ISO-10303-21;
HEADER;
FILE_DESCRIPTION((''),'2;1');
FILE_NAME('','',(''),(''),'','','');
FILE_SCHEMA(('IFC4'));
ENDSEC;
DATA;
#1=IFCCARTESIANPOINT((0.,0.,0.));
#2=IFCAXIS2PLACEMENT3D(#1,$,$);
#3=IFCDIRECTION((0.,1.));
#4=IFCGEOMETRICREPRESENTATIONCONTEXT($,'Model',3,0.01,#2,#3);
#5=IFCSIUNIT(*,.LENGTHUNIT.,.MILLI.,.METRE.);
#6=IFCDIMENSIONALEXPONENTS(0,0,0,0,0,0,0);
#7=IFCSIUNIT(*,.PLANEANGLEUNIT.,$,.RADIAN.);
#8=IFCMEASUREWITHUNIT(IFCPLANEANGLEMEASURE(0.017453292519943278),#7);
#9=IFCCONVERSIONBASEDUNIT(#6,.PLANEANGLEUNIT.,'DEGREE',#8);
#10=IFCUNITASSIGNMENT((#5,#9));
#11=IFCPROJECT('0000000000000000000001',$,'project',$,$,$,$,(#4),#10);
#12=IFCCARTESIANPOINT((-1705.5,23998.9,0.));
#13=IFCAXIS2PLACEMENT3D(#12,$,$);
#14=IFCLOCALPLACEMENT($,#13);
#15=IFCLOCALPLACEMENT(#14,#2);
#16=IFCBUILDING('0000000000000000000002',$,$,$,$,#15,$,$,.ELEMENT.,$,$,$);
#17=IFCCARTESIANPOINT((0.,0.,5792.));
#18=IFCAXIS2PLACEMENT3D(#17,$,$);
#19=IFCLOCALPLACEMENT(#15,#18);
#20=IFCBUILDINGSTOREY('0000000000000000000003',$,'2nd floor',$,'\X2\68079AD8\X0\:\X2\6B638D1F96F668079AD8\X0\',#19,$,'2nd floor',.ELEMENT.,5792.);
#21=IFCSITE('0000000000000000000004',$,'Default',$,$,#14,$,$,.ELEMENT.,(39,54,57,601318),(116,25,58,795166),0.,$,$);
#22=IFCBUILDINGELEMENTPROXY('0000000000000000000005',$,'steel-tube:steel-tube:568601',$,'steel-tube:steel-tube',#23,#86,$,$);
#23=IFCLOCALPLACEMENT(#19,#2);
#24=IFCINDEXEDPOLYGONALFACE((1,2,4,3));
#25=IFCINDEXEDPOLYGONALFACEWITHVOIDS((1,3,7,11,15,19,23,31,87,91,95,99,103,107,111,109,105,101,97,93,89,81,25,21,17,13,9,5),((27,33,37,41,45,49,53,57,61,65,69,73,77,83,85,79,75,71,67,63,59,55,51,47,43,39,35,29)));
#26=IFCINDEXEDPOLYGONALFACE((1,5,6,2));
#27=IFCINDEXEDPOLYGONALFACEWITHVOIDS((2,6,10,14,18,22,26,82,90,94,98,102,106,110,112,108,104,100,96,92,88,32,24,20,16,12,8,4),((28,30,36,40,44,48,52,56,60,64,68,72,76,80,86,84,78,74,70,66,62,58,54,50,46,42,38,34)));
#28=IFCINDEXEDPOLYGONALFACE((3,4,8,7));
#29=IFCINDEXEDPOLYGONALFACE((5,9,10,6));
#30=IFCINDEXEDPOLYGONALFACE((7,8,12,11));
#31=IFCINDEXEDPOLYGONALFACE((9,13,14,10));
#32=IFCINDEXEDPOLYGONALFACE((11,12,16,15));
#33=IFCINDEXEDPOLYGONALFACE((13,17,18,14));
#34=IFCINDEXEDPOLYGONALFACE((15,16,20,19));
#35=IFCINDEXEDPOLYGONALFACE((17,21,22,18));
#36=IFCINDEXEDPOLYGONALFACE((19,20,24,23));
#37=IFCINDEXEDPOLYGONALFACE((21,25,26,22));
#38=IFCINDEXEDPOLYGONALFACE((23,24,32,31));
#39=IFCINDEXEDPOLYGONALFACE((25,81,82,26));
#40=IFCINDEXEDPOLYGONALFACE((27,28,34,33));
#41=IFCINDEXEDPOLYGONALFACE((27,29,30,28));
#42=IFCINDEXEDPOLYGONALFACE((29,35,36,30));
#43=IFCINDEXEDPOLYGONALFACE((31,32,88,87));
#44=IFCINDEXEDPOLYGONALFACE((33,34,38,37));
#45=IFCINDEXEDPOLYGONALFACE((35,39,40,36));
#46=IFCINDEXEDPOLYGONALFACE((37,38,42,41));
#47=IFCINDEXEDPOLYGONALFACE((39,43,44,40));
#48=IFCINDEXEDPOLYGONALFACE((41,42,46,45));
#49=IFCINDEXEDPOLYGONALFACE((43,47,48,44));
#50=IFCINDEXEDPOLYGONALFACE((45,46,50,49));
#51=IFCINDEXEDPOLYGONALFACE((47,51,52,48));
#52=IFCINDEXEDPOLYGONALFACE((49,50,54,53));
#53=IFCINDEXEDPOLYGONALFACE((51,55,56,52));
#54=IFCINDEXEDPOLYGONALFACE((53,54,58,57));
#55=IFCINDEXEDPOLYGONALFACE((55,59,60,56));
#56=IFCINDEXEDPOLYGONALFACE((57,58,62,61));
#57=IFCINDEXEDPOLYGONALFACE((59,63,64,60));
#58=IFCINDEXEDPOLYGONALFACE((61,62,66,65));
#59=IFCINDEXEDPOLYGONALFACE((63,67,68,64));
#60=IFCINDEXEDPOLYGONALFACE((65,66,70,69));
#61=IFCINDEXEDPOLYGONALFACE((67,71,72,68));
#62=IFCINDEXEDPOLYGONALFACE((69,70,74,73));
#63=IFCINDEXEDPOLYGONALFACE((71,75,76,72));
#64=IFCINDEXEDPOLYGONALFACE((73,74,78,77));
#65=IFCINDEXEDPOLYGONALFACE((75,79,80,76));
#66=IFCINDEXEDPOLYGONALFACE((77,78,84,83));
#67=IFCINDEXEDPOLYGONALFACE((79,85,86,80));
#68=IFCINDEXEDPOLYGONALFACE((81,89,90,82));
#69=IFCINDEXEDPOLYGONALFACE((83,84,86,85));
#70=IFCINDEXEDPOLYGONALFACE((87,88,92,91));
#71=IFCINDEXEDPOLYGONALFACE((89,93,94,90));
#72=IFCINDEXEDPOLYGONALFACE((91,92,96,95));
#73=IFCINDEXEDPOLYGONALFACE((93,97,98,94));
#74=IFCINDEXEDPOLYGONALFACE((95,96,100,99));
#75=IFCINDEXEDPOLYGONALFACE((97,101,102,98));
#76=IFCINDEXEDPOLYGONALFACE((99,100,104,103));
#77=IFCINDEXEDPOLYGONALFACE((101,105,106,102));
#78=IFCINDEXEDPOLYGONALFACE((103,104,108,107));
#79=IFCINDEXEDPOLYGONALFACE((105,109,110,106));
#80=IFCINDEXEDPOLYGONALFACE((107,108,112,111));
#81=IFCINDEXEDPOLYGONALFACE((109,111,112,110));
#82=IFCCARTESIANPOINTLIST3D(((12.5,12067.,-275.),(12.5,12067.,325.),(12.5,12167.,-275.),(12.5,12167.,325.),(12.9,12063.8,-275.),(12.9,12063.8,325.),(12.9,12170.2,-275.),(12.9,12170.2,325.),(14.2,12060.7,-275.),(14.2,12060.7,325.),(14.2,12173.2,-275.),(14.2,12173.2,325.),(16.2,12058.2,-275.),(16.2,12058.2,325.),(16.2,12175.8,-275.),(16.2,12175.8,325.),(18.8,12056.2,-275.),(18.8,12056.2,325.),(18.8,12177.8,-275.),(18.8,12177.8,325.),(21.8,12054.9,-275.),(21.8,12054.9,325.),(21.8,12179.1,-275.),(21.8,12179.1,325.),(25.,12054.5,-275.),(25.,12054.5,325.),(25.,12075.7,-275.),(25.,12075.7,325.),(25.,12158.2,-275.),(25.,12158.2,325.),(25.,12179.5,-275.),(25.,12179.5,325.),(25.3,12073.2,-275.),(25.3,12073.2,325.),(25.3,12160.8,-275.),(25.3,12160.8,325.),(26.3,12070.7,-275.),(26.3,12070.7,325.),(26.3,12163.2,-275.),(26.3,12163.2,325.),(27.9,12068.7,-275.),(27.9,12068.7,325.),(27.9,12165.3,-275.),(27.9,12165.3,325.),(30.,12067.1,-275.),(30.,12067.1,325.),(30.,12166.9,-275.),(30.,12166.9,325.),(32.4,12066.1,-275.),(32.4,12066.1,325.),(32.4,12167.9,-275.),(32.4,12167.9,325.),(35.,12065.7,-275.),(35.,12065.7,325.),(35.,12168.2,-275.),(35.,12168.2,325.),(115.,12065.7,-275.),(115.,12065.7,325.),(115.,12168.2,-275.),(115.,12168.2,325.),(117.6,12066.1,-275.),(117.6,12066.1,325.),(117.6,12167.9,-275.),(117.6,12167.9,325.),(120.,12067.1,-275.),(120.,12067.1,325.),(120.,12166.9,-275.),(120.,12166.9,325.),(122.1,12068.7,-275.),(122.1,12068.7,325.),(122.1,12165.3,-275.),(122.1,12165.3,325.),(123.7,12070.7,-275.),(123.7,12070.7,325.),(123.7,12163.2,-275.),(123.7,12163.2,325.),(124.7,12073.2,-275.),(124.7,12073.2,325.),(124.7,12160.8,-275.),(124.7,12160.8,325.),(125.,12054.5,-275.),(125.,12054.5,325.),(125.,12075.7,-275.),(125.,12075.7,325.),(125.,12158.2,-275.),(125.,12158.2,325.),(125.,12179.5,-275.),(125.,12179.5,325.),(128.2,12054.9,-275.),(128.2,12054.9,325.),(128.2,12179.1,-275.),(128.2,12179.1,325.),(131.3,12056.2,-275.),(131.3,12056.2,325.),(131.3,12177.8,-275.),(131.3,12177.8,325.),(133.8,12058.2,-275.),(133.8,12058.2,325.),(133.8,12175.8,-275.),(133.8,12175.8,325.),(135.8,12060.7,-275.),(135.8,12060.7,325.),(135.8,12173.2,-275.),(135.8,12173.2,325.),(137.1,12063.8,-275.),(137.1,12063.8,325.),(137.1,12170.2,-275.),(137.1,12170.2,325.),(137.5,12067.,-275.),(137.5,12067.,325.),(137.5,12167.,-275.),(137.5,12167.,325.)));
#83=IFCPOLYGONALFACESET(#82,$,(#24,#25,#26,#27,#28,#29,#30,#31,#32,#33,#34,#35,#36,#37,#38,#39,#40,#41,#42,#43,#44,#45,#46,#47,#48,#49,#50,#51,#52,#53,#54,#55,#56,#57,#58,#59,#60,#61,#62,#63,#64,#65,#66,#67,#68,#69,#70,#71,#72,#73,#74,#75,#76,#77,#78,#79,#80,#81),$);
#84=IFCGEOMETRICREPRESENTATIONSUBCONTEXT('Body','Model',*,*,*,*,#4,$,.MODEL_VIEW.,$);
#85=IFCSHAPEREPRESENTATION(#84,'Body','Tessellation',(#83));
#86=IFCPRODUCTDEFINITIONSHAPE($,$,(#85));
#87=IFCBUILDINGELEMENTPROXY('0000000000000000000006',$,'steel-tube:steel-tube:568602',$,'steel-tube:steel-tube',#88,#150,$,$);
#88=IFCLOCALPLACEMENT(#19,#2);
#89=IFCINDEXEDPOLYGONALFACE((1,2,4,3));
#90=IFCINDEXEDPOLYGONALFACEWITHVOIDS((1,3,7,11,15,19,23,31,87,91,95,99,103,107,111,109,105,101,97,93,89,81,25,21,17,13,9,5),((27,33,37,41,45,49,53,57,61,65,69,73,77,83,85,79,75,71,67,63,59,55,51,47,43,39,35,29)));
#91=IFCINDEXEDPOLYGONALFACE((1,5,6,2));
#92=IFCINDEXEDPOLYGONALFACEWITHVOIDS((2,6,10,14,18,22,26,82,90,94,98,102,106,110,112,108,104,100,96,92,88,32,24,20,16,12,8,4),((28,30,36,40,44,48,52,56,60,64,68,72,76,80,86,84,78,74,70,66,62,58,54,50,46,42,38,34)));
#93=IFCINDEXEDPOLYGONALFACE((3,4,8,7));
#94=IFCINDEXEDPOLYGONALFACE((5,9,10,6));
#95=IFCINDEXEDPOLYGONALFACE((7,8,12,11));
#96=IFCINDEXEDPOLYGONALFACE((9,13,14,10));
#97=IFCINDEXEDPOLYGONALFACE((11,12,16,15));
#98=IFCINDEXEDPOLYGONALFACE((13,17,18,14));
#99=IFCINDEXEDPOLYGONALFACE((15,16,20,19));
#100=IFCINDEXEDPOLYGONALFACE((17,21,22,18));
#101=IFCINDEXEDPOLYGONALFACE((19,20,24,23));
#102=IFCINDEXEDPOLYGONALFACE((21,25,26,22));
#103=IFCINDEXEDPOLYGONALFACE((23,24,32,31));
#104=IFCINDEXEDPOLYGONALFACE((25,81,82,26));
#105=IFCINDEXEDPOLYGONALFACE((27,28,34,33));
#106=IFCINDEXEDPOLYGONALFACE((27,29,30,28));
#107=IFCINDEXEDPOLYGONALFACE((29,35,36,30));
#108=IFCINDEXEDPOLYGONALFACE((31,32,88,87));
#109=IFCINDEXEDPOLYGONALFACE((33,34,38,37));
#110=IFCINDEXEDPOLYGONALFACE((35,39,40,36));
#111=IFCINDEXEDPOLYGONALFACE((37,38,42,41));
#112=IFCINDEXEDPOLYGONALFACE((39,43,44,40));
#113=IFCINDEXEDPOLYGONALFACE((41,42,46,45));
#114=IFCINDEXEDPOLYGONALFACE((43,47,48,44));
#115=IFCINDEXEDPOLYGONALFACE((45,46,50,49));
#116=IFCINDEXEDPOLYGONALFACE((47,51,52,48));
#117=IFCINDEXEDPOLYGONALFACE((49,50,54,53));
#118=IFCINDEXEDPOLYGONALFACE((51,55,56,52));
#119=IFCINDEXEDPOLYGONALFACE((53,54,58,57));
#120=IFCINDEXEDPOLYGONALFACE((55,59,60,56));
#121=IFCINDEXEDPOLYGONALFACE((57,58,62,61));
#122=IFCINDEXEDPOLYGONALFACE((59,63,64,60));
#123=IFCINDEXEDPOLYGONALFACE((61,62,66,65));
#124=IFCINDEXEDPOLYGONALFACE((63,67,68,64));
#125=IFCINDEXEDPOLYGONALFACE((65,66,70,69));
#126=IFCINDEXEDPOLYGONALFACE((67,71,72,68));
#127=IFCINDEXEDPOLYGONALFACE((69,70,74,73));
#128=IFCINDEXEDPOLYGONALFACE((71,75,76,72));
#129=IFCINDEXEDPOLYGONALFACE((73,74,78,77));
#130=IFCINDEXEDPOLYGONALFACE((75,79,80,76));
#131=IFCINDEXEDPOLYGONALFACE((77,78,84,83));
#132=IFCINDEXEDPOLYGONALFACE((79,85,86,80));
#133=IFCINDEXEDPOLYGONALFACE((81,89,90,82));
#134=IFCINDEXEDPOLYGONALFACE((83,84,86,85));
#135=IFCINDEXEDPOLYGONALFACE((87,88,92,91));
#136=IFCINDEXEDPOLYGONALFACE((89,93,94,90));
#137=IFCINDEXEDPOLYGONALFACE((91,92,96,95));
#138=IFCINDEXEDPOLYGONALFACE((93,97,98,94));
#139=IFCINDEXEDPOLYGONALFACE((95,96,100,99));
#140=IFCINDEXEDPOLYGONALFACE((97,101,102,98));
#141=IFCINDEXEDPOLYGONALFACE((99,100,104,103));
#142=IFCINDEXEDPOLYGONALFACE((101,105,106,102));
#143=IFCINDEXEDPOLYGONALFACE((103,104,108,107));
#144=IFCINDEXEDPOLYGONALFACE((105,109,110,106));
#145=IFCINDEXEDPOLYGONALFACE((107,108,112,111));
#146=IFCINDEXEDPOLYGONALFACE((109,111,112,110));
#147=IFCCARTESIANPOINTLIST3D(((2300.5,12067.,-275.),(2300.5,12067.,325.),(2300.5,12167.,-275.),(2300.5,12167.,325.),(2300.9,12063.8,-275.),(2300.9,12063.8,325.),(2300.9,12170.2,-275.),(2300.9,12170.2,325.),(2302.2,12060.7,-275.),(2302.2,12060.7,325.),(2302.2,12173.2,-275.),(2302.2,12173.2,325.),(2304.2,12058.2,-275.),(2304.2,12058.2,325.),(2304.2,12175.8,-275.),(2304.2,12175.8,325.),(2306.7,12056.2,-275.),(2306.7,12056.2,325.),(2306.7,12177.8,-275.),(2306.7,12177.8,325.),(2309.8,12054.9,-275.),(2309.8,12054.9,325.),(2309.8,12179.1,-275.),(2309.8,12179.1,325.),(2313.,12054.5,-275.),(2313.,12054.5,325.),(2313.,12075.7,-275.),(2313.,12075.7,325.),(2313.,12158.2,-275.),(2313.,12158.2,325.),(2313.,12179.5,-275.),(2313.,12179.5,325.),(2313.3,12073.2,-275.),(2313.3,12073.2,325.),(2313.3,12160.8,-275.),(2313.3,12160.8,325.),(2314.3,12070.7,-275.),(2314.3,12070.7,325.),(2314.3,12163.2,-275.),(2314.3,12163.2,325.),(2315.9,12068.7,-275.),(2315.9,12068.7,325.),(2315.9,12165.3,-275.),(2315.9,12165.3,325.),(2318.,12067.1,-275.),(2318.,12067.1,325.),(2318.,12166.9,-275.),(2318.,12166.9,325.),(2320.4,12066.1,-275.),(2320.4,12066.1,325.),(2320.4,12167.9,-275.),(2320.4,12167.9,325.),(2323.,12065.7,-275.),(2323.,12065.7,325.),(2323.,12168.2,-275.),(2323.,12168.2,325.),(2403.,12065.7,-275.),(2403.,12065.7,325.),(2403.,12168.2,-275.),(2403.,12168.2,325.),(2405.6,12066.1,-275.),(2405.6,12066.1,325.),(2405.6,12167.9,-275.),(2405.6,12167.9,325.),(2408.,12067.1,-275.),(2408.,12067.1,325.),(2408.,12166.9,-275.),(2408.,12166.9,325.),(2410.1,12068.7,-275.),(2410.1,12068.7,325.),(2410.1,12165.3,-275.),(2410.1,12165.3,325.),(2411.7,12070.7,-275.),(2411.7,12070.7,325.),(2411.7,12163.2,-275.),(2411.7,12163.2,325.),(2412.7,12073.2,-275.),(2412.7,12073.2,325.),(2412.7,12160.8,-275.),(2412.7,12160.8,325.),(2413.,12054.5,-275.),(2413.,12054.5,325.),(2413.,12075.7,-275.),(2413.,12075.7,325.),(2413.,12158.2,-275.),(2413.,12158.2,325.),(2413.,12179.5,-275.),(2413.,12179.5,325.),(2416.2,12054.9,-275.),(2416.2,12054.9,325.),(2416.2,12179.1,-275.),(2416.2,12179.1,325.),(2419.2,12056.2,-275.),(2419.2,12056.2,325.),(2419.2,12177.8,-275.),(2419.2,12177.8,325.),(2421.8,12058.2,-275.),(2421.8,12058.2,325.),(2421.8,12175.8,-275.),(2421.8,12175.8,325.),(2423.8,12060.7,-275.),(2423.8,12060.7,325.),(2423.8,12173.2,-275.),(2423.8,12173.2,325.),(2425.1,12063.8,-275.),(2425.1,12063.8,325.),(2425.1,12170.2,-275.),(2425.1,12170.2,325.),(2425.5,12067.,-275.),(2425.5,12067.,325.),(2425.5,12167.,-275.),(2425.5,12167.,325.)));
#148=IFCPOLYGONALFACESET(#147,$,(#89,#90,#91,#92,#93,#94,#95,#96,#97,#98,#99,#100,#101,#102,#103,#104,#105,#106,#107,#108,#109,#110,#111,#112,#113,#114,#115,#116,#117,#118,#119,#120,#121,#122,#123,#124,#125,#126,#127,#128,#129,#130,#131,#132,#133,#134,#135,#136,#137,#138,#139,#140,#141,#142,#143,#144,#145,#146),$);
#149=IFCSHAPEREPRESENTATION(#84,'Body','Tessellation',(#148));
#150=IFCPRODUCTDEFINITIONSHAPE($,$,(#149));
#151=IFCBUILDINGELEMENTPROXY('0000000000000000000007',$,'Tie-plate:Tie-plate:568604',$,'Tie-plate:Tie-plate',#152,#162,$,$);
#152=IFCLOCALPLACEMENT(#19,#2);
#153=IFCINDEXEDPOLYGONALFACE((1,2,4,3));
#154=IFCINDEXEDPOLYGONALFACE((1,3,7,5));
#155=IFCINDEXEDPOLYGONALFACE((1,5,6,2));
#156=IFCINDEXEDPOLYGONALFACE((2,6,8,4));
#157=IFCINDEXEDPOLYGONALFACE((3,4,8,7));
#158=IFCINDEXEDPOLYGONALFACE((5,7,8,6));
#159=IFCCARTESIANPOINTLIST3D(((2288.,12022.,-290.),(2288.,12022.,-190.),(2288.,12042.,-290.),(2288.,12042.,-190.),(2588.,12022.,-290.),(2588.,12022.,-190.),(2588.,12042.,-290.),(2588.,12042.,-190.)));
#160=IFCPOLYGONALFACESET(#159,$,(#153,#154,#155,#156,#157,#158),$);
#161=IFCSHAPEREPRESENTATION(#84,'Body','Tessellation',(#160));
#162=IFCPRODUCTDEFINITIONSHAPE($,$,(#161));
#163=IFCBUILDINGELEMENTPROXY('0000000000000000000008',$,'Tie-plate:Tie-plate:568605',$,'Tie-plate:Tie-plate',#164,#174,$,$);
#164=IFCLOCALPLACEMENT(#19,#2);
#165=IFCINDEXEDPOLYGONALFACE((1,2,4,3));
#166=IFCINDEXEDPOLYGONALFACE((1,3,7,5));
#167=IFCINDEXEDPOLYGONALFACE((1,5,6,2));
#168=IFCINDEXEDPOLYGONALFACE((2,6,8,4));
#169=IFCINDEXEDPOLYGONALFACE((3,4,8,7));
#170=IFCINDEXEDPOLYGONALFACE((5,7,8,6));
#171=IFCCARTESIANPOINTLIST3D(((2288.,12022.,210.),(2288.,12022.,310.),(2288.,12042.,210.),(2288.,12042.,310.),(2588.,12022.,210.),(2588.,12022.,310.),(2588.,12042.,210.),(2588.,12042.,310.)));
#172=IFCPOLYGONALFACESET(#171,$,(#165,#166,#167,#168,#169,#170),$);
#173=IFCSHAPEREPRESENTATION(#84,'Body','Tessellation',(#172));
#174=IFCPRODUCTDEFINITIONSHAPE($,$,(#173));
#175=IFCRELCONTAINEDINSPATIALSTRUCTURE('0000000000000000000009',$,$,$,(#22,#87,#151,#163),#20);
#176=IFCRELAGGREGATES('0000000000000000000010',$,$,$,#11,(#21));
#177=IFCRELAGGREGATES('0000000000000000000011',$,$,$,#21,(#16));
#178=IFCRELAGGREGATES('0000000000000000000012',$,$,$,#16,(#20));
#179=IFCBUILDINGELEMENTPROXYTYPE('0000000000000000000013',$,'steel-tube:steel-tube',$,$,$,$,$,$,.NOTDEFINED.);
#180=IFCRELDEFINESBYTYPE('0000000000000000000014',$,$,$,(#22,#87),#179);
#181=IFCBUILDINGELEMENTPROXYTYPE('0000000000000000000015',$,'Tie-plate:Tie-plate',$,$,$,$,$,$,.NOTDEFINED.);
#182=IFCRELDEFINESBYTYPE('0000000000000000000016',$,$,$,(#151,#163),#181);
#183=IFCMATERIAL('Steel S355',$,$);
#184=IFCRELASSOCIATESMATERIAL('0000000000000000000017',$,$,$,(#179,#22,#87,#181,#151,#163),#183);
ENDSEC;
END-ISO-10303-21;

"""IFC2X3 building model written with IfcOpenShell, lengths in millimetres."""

from ifc_helpers import new_model, entity, si_unit, converted_unit, direction, frame, frame_2d, origin, place, context, subcontext, project, spatial, polyline, circle_curve, parameter, trimmed, segment, composite_curve, rectangle, outline, extrude, source, transform, mapped, material, type_object, type_shapes, element, save


model = new_model("IFC2X3")

# Units and contexts
model_context = context("Model", 3, precision=0.01, world=origin(), true_north=direction((0.0, 1.0)))
body_context = subcontext(model_context, "Body", "Model", "MODEL_VIEW")
ifc_project = project(units=[si_unit("LENGTHUNIT", "METRE", prefix="MILLI"), converted_unit("PLANEANGLEUNIT", "DEGREE", entity("IfcPlaneAngleMeasure", 0.017453292519943278), si_unit("PLANEANGLEUNIT", "RADIAN"), dimensions=[0, 0, 0, 0, 0, 0, 0])], contexts=[model_context])

# Site, building, storey
site_placement = place(None, frame((-1705.5, 23998.9, 0.0)))
site = spatial("IfcSite", under=ifc_project, at=site_placement, Name="Default", CompositionType="ELEMENT", RefLatitude=(39, 54, 57, 601318), RefLongitude=(116, 25, 58, 795166), RefElevation=0.0)
building_placement = place(site_placement, origin())
building = spatial("IfcBuilding", under=site, at=building_placement, CompositionType="ELEMENT")
storey_placement = place(building_placement, frame((0.0, 0.0, 5792.0)))
storey = spatial("IfcBuildingStorey", under=building, at=storey_placement, Name="2nd floor", ObjectType="标高:正负零标高", LongName="2nd floor", CompositionType="ELEMENT", Elevation=5792.0)

# Shared definitions
ifc_material_1 = material(Name="Steel S355")

# Building element proxies
building_element_proxy_type_1 = type_object("IfcBuildingElementProxyType", Name="steel-tube:steel-tube", PredefinedType="NOTDEFINED", material=ifc_material_1)
shared_shape_1 = source(origin(), body_context, "Body", "SweptSolid", [
    extrude(outline(composite_curve([segment(trimmed(circle_curve(frame_2d((50.0, -50.0), x_axis=(1.0, 0.0)), 12.5), [parameter(270.0)], [parameter(0.0)], True, "PARAMETER"), True, "CONTINUOUS"), segment(polyline([(62.5, -50.0), (62.5, 50.0)]), True, "CONTINUOUS"), segment(trimmed(circle_curve(frame_2d((50.0, 50.0), x_axis=(1.0, 0.0)), 12.5), [parameter(0.0)], [parameter(90.0)], True, "PARAMETER"), True, "CONTINUOUS"), segment(polyline([(50.0, 62.5), (-50.0, 62.5)]), True, "CONTINUOUS"), segment(trimmed(circle_curve(frame_2d((-50.0, 50.0), x_axis=(1.0, 0.0)), 12.5), [parameter(90.0)], [parameter(180.0)], True, "PARAMETER"), True, "CONTINUOUS"), segment(polyline([(-62.5, 50.0), (-62.5, -50.0)]), True, "CONTINUOUS"), segment(trimmed(circle_curve(frame_2d((-50.0, -50.0), x_axis=(1.0, 0.0)), 12.5), [parameter(180.0)], [parameter(270.0)], True, "PARAMETER"), True, "CONTINUOUS"), segment(polyline([(-50.0, -62.5), (50.0, -62.5)]), True, "CONTINUOUS")], self_intersect=False), holes=[composite_curve([segment(trimmed(circle_curve(frame_2d((-41.2, 40.0), x_axis=(1.0, 0.0)), 10.0), [parameter(90.0)], [parameter(180.0)], True, "PARAMETER"), False, "CONTINUOUS"), segment(polyline([(-41.3, 50.0), (41.2, 50.0)]), True, "CONTINUOUS"), segment(trimmed(circle_curve(frame_2d((41.2, 40.0), x_axis=(1.0, 0.0)), 10.0), [parameter(0.0)], [parameter(90.0)], True, "PARAMETER"), False, "CONTINUOUS"), segment(polyline([(51.2, 40.0), (51.2, -40.0)]), True, "CONTINUOUS"), segment(trimmed(circle_curve(frame_2d((41.2, -40.0), x_axis=(1.0, 0.0)), 10.0), [parameter(270.0)], [parameter(360.0)], True, "PARAMETER"), False, "CONTINUOUS"), segment(polyline([(41.2, -50.0), (-41.3, -50.0)]), True, "CONTINUOUS"), segment(trimmed(circle_curve(frame_2d((-41.3, -40.0), x_axis=(1.0, 0.0)), 10.0), [parameter(180.0)], [parameter(270.0)], True, "PARAMETER"), False, "CONTINUOUS"), segment(polyline([(-51.3, -40.0), (-51.3, 40.0)]), True, "CONTINUOUS")], self_intersect=False)]), frame((62.5, 62.5, -175.0)), (0.0, 0.0, 1.0), 600.0),
])
type_shapes(building_element_proxy_type_1, [shared_shape_1])
for number, where, z_axis, x_axis, name in (
    (1, (12.5, 12179.5, -100.0), (0.0, 0.0, 1.0), (0.0, -1.0, 0.0), "steel-tube:steel-tube:568601"),
    (2, (2300.5, 12179.5, -100.0), (0.0, 0.0, 1.0), (0.0, -1.0, 0.0), "steel-tube:steel-tube:568602"),
):
    element("IfcBuildingElementProxy", number, at=place(storey_placement, frame(where, z_axis=z_axis, x_axis=x_axis)), inside=storey, type_object=building_element_proxy_type_1, material=ifc_material_1, Name=name, ObjectType="steel-tube:steel-tube", context=body_context, shape_type="MappedRepresentation", body=[
        mapped(shared_shape_1, transform((0.0, 0.0, 0.0), scale=1.0)),
    ])
building_element_proxy_type_2 = type_object("IfcBuildingElementProxyType", Name="Tie-plate:Tie-plate", PredefinedType="NOTDEFINED", material=ifc_material_1)
shared_shape_2 = source(origin(), body_context, "Body", "SweptSolid", [
    extrude(rectangle(XDim=300.0, YDim=20.0, at=frame_2d((0.0, 0.0), x_axis=(1.0, 0.0))), frame((150.0, -10.0, 0.0), z_axis=(0.0, 0.0, 1.0), x_axis=(-1.0, 0.0, 0.0)), (0.0, 0.0, 1.0), 100.0),
])
type_shapes(building_element_proxy_type_2, [shared_shape_2])
for number, where, name in (
    (3, (2288.0, 12042.0, -290.0), "Tie-plate:Tie-plate:568604"),
    (4, (2288.0, 12042.0, 210.0), "Tie-plate:Tie-plate:568605"),
):
    element("IfcBuildingElementProxy", number, at=place(storey_placement, frame(where)), inside=storey, type_object=building_element_proxy_type_2, material=ifc_material_1, Name=name, ObjectType="Tie-plate:Tie-plate", context=body_context, shape_type="MappedRepresentation", body=[
        mapped(shared_shape_2, transform((0.0, 0.0, 0.0), scale=1.0)),
    ])

save(model, "model.ifc")
